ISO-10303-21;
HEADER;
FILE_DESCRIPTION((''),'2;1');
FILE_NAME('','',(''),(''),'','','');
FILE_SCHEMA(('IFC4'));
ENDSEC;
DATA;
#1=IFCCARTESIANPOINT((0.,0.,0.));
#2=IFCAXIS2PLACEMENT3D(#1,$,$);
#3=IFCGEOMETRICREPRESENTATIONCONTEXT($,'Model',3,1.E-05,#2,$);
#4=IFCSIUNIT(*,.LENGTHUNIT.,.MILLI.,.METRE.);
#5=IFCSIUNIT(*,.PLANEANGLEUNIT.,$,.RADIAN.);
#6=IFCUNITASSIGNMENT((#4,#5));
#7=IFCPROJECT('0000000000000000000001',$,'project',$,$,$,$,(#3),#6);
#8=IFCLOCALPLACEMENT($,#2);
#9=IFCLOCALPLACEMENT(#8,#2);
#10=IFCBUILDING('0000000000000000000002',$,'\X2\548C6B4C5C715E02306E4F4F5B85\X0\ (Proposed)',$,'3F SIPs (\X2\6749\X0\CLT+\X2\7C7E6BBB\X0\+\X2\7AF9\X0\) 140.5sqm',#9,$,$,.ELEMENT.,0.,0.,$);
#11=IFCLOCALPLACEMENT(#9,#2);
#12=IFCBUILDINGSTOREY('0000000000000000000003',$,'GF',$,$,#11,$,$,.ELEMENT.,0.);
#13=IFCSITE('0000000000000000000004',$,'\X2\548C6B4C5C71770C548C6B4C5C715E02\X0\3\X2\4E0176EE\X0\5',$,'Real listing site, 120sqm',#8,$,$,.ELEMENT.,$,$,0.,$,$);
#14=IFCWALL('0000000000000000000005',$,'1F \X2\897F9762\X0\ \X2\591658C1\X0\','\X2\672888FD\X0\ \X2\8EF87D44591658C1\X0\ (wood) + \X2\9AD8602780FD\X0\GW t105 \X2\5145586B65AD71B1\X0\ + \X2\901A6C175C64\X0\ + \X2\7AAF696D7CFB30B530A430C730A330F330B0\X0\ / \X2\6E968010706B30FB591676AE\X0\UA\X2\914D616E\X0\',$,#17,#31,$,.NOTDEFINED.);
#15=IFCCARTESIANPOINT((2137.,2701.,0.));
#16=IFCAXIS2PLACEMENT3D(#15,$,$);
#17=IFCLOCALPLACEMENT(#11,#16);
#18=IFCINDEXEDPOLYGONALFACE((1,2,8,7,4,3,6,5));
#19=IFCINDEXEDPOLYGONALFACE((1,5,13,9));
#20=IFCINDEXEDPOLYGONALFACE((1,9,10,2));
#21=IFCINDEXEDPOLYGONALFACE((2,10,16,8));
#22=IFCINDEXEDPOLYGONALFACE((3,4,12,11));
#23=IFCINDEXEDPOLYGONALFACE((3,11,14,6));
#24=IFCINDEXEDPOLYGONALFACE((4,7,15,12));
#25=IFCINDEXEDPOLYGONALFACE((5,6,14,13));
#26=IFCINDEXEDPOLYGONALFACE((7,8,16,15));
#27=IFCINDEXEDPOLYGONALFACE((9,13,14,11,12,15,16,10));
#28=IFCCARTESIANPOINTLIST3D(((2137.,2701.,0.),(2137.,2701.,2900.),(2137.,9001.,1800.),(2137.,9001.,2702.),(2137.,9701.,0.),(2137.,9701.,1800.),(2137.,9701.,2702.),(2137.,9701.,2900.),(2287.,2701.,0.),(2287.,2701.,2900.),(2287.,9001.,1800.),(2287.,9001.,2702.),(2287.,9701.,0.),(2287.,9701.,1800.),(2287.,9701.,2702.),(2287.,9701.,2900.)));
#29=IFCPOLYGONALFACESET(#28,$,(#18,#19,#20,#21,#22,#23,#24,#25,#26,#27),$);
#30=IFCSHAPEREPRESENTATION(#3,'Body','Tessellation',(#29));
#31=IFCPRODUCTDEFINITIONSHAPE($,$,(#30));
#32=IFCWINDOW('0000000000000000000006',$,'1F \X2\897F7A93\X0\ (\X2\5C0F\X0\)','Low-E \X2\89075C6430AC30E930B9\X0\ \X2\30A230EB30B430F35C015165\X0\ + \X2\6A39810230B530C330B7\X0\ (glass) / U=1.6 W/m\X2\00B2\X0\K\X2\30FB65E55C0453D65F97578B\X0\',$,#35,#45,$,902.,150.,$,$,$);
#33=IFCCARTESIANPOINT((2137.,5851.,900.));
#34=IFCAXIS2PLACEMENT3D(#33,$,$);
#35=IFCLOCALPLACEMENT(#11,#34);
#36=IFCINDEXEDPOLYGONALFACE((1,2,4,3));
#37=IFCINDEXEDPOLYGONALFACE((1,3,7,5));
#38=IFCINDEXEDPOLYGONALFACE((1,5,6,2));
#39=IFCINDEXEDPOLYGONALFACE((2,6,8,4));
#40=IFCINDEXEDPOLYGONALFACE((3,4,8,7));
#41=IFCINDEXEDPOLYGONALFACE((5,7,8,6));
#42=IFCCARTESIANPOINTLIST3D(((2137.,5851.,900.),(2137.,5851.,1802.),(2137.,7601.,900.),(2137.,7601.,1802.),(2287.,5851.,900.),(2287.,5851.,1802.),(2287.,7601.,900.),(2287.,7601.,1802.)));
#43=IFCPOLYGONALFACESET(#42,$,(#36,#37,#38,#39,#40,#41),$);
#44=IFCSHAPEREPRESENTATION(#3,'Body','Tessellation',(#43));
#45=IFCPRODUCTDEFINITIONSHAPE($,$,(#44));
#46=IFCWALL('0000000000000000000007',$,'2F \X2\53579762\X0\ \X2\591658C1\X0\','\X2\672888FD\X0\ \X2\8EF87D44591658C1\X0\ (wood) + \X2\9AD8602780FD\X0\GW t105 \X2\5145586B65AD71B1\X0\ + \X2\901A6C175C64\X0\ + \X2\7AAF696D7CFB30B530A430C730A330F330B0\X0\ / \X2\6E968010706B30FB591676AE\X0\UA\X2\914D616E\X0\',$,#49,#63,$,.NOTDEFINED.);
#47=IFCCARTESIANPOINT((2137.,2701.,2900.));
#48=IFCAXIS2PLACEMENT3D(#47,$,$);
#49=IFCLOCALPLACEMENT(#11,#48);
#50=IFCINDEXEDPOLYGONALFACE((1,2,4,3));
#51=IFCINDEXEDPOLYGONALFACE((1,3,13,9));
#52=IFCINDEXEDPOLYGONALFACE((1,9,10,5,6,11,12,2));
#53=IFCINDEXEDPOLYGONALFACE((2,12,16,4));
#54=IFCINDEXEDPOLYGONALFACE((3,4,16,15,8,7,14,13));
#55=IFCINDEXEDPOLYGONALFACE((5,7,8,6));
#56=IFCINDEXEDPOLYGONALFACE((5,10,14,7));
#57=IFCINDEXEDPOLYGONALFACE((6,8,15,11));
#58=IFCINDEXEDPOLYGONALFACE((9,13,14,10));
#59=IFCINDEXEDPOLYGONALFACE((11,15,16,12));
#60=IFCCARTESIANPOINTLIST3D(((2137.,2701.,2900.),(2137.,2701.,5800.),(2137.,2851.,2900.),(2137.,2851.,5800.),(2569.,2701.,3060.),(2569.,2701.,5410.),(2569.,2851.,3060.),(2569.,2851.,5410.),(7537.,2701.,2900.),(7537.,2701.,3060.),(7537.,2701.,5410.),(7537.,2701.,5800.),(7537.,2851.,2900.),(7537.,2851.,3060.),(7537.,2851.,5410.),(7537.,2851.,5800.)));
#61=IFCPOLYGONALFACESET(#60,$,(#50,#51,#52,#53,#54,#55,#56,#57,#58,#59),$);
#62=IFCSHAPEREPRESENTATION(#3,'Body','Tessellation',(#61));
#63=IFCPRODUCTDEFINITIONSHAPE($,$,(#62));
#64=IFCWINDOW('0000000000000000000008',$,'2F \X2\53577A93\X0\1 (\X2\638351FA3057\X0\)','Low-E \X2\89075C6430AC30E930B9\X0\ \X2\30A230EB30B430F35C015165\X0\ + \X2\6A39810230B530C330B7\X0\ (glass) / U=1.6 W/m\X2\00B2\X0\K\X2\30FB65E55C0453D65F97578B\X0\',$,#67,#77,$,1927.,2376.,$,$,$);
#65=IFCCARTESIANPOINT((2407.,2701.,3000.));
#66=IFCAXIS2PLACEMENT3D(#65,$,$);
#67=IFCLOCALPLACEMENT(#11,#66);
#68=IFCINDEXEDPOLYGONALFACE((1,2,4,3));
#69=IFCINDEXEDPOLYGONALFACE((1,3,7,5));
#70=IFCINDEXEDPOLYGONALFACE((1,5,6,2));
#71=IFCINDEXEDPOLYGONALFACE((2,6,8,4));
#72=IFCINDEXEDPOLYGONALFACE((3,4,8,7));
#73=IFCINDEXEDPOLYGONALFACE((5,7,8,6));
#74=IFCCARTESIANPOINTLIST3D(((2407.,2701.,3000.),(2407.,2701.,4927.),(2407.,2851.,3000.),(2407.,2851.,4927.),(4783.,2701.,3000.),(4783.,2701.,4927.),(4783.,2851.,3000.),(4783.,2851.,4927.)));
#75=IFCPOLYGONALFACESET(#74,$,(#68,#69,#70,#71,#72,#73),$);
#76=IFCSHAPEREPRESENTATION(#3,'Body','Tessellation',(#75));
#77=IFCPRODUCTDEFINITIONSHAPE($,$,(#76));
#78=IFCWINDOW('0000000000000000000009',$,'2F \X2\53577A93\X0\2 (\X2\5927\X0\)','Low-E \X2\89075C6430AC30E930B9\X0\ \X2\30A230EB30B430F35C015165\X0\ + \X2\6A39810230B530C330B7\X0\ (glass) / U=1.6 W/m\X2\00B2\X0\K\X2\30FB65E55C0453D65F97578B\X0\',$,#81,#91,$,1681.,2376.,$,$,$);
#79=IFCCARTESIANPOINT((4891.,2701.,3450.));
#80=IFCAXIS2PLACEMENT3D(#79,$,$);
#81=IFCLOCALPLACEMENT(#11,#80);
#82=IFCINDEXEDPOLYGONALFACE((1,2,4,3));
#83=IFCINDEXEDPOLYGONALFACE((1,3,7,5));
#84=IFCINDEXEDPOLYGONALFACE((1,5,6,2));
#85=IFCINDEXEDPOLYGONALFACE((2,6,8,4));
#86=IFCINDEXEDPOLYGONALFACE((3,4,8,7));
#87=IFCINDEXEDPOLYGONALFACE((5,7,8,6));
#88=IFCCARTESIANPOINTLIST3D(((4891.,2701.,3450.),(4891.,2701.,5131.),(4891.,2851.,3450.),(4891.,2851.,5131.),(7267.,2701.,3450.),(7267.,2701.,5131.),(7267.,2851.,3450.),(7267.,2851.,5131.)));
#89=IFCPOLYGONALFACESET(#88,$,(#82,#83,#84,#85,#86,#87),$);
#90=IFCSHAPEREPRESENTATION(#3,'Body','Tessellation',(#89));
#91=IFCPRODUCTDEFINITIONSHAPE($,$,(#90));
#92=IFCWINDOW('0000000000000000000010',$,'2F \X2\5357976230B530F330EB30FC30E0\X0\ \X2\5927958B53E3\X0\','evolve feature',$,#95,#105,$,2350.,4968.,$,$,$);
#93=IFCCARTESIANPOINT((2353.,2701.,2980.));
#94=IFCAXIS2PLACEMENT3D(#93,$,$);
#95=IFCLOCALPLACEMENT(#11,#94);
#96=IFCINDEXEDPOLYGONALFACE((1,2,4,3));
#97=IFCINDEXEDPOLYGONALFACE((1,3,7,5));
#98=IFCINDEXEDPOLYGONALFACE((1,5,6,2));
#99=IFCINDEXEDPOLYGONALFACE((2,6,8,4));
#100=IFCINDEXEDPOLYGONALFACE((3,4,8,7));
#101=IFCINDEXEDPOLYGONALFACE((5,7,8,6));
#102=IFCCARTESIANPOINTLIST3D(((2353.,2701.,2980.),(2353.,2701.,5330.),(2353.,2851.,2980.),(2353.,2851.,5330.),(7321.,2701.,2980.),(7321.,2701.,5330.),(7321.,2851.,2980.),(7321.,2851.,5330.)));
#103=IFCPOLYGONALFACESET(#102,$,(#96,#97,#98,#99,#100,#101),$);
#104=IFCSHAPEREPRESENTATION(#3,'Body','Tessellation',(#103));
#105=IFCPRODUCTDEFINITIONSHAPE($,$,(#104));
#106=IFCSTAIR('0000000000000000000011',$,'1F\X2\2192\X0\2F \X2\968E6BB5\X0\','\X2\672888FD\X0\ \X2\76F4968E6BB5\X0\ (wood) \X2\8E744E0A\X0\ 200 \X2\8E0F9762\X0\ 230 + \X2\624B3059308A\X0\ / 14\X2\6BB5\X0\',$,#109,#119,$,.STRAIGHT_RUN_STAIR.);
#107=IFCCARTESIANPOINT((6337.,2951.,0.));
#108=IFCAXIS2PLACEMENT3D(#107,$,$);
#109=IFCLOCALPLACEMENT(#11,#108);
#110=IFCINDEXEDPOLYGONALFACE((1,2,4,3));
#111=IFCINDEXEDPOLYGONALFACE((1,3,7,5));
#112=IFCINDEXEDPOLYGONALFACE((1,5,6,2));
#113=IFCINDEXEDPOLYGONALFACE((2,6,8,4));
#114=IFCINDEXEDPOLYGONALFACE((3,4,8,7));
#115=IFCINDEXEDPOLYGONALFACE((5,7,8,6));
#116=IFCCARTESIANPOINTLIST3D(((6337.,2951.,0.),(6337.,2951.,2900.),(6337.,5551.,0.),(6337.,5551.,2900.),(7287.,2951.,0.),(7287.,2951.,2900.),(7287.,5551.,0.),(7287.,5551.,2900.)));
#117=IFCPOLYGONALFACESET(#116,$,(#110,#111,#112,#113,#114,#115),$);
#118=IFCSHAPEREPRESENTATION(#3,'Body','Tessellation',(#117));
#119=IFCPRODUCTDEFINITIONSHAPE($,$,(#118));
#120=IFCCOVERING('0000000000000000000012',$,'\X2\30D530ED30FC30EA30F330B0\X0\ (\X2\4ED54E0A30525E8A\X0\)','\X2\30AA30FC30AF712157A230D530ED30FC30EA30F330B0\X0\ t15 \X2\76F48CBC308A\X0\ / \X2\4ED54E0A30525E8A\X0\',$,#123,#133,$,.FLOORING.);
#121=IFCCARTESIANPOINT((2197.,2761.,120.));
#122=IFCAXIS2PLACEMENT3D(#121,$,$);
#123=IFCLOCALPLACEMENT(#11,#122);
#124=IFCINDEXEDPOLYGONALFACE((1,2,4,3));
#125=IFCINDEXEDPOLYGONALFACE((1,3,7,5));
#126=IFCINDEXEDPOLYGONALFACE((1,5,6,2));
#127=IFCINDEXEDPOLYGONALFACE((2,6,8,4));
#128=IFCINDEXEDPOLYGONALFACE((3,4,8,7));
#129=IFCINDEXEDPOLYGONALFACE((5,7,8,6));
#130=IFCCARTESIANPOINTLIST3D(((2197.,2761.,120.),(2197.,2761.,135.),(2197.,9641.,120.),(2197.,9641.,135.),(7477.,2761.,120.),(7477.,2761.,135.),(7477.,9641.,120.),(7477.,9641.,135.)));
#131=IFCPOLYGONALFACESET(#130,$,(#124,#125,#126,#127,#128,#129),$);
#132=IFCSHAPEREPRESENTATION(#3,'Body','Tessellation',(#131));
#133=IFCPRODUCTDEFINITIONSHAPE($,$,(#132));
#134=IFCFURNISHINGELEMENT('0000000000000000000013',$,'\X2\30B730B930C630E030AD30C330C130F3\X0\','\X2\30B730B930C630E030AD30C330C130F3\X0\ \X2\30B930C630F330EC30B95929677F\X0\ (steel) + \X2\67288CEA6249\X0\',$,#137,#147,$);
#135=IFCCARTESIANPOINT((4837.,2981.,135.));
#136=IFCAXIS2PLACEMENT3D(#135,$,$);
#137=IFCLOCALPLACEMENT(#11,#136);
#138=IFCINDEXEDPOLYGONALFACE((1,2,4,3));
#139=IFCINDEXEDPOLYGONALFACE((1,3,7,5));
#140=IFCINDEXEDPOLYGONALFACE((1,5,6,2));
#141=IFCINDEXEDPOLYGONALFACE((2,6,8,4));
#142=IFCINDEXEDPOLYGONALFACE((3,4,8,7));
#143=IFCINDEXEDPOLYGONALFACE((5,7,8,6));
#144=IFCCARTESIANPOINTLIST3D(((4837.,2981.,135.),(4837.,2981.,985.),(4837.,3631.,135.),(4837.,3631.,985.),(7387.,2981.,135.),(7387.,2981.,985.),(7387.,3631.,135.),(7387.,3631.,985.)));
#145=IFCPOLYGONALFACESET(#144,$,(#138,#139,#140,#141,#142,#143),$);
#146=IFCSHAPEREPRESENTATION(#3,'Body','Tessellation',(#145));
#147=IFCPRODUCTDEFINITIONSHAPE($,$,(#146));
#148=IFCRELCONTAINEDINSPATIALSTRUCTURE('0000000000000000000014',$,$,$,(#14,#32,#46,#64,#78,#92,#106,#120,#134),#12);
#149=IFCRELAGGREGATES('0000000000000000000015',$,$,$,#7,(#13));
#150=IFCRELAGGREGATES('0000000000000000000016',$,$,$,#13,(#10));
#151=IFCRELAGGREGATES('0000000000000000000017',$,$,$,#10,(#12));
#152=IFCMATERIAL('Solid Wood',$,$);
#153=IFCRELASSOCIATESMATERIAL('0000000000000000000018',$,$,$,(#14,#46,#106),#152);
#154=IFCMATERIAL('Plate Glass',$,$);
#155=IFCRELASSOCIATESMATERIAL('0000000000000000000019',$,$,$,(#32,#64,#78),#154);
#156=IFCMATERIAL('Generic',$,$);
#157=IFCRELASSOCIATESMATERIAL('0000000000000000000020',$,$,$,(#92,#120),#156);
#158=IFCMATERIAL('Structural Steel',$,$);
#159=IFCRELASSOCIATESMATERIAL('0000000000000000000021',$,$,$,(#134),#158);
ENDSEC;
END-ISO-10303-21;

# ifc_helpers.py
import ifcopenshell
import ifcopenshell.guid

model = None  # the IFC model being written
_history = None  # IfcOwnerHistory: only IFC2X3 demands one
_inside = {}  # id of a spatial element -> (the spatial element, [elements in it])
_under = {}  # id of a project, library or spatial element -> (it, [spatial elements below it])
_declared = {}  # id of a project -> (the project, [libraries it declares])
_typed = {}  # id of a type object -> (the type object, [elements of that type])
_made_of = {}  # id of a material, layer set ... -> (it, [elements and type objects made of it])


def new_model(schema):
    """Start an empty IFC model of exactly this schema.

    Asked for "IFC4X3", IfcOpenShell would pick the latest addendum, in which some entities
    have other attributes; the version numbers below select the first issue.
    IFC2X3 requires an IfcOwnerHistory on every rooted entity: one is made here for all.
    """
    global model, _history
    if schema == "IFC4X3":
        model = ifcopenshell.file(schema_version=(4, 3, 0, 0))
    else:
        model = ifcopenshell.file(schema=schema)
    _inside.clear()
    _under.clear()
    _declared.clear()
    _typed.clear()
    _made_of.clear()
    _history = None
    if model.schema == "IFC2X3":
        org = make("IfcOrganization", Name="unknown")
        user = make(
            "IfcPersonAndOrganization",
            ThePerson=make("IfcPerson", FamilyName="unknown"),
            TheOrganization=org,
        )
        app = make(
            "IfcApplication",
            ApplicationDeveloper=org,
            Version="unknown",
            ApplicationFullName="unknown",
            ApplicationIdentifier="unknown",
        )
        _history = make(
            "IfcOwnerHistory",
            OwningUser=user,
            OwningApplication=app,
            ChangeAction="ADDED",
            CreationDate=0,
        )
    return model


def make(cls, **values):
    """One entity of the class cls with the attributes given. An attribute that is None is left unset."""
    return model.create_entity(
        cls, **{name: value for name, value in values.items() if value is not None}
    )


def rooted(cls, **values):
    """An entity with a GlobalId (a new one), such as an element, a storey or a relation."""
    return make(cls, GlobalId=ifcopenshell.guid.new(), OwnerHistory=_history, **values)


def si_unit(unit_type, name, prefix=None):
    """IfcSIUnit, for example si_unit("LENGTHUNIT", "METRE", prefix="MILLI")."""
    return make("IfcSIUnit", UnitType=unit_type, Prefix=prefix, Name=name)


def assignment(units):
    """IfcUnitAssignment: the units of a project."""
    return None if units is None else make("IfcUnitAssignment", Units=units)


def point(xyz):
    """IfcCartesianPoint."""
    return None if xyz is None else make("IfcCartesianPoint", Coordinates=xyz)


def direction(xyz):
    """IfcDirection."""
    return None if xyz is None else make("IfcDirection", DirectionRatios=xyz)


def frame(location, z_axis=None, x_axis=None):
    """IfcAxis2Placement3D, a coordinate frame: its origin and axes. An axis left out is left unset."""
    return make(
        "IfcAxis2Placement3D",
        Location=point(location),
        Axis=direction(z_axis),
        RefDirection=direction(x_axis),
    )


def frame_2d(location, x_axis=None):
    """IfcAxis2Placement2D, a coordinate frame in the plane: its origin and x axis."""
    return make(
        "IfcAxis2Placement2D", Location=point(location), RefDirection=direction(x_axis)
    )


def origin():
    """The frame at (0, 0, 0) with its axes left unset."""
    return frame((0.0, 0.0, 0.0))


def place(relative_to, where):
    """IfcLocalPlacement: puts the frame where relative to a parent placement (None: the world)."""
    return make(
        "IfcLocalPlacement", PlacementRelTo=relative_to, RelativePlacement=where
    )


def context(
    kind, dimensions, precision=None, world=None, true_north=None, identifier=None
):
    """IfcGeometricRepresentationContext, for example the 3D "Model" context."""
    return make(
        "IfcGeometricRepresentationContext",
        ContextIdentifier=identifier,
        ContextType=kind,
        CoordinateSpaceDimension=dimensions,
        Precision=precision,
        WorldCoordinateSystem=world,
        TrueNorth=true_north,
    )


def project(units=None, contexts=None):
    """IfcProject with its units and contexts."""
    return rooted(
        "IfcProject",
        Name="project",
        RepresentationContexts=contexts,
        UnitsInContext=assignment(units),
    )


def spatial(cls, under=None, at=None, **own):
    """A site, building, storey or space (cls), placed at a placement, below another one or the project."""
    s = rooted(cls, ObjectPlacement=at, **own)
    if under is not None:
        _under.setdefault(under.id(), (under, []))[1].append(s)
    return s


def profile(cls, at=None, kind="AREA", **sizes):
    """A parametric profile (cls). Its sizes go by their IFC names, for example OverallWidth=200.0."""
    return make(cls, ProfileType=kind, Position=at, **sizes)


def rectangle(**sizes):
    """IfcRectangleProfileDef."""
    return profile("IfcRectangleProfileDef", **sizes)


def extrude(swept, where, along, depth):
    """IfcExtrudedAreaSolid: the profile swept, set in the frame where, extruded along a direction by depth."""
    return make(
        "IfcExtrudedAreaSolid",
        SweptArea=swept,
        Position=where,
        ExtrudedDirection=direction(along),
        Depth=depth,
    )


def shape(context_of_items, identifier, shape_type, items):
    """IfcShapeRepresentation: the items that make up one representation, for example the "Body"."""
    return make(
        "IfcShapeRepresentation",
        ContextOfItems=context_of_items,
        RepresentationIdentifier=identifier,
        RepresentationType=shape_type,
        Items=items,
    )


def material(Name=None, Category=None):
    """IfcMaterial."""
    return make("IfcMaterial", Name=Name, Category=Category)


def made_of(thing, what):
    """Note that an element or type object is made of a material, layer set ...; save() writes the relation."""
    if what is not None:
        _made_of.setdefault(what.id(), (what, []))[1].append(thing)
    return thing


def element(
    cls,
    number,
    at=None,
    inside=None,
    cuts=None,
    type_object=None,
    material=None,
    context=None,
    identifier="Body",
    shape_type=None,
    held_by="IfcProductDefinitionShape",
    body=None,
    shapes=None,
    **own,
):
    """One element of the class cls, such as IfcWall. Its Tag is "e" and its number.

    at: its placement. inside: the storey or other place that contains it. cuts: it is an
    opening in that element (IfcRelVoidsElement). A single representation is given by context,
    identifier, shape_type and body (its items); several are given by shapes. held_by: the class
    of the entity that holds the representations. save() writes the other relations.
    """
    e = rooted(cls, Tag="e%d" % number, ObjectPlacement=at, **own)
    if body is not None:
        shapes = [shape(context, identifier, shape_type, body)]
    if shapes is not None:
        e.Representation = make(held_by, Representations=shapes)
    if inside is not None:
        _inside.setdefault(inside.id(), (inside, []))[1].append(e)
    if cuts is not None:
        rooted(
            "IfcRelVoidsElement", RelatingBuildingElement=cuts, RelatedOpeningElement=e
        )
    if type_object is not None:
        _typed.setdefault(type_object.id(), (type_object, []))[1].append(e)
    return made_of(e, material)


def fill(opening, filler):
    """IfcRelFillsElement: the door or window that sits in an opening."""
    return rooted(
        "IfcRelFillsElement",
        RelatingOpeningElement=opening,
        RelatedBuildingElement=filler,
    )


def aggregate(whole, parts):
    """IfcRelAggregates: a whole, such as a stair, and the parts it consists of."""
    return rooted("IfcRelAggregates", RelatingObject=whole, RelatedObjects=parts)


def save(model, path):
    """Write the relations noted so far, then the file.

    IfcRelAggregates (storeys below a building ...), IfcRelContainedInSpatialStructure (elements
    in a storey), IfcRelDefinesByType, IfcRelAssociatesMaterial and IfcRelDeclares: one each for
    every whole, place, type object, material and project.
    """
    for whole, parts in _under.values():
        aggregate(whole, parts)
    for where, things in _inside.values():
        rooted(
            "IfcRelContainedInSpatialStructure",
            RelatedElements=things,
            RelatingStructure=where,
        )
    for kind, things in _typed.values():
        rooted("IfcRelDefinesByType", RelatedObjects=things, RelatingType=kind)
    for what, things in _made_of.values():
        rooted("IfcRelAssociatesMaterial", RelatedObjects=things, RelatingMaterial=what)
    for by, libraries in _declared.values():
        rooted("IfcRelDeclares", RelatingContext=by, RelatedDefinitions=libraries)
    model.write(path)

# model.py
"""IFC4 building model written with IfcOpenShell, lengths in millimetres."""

from ifc_helpers import new_model, si_unit, frame, frame_2d, origin, place, context, project, spatial, rectangle, extrude, material, element, fill, save


model = new_model("IFC4")

# Units and contexts
model_context = context("Model", 3, precision=1e-05, world=origin())
ifc_project = project(units=[si_unit("LENGTHUNIT", "METRE", prefix="MILLI"), si_unit("PLANEANGLEUNIT", "RADIAN")], contexts=[model_context])

# Site, building, storey
site_placement = place(None, origin())
site = spatial("IfcSite", under=ifc_project, at=site_placement, Name="和歌山県和歌山市3丁目5", ObjectType="Real listing site, 120sqm", CompositionType="ELEMENT", RefElevation=0.0)
building_placement = place(site_placement, origin())
building = spatial("IfcBuilding", under=site, at=building_placement, Name="和歌山市の住宅 (Proposed)", ObjectType="3F SIPs (杉CLT+籾殻+竹) 140.5sqm", CompositionType="ELEMENT", ElevationOfRefHeight=0.0, ElevationOfTerrain=0.0)
storey_placement = place(building_placement, origin())
storey = spatial("IfcBuildingStorey", under=building, at=storey_placement, Name="GF", CompositionType="ELEMENT", Elevation=0.0)

# Shared definitions
ifc_material_1 = material(Name="Solid Wood")
ifc_material_2 = material(Name="Generic")

# Shared definitions
ifc_material_3 = material(Name="Plate Glass")

# Wall, opening, window
wall_1_placement = place(storey_placement, frame((2137.0, 2701.0, 0.0)))
wall_1 = element("IfcWall", 1, at=wall_1_placement, inside=storey, material=ifc_material_1, Name="1F 西面 外壁", Description="木製 軸組外壁 (wood) + 高性能GW t105 充填断熱 + 通気層 + 窯業系サイディング / 準耐火・外皮UA配慮", PredefinedType="NOTDEFINED", context=model_context, shape_type="SweptSolid", body=[
    extrude(rectangle(XDim=150.0, YDim=7000.0, at=frame_2d((75.0, 3500.0))), frame((2137.0, 2701.0, 0.0)), (0.0, 0.0, 1.0), 2900.0),
])
opening_1_placement = place(storey_placement, frame((2137.0, 5851.0, 900.0)))
opening_1 = element("IfcOpeningElement", 2, at=opening_1_placement, cuts=wall_1, PredefinedType="NOTDEFINED", context=model_context, shape_type="SweptSolid", body=[
    extrude(rectangle(XDim=150.0, YDim=1750.0, at=frame_2d((75.0, 875.0))), frame((2137.0, 5851.0, 900.0)), (0.0, 0.0, 1.0), 902.0),
])
window_1_placement = place(storey_placement, frame((2137.0, 5851.0, 900.0)))
window_1 = element("IfcWindow", 3, at=window_1_placement, inside=storey, material=ifc_material_3, Name="1F 西窓 (小)", Description="Low-E 複層ガラス アルゴン封入 + 樹脂サッシ (glass) / U=1.6 W/m²K・日射取得型", OverallHeight=902.0, OverallWidth=150.0, context=model_context, shape_type="SweptSolid", body=[
    extrude(rectangle(XDim=150.0, YDim=1750.0, at=frame_2d((75.0, 875.0))), frame((2137.0, 5851.0, 900.0)), (0.0, 0.0, 1.0), 902.0),
])
fill(opening_1, window_1)

# Wall, openings, windows
wall_2_placement = place(storey_placement, frame((2137.0, 2701.0, 2900.0)))
wall_2 = element("IfcWall", 4, at=wall_2_placement, inside=storey, material=ifc_material_1, Name="2F 南面 外壁", Description="木製 軸組外壁 (wood) + 高性能GW t105 充填断熱 + 通気層 + 窯業系サイディング / 準耐火・外皮UA配慮", PredefinedType="NOTDEFINED", context=model_context, shape_type="SweptSolid", body=[
    extrude(rectangle(XDim=5400.0, YDim=150.0, at=frame_2d((2700.0, 75.0))), frame((2137.0, 2701.0, 2900.0)), (0.0, 0.0, 1.0), 2900.0),
])
opening_2_placement = place(storey_placement, frame((2407.0, 2701.0, 3000.0)))
opening_2 = element("IfcOpeningElement", 5, at=opening_2_placement, cuts=wall_2, PredefinedType="NOTDEFINED", context=model_context, shape_type="SweptSolid", body=[
    extrude(rectangle(XDim=2376.0, YDim=150.0, at=frame_2d((1188.0, 75.0))), frame((2407.0, 2701.0, 3000.0)), (0.0, 0.0, 1.0), 1927.0),
])
opening_3_placement = place(storey_placement, frame((4891.0, 2701.0, 3450.0)))
opening_3 = element("IfcOpeningElement", 6, at=opening_3_placement, cuts=wall_2, PredefinedType="NOTDEFINED", context=model_context, shape_type="SweptSolid", body=[
    extrude(rectangle(XDim=2376.0, YDim=150.0, at=frame_2d((1188.0, 75.0))), frame((4891.0, 2701.0, 3450.0)), (0.0, 0.0, 1.0), 1681.0),
])
opening_4_placement = place(storey_placement, frame((2353.0, 2701.0, 2980.0)))
opening_4 = element("IfcOpeningElement", 7, at=opening_4_placement, cuts=wall_2, PredefinedType="NOTDEFINED", context=model_context, shape_type="SweptSolid", body=[
    extrude(rectangle(XDim=4968.0, YDim=150.0, at=frame_2d((2484.0, 75.0))), frame((2353.0, 2701.0, 2980.0)), (0.0, 0.0, 1.0), 2350.0),
])
window_2_placement = place(storey_placement, frame((2407.0, 2701.0, 3000.0)))
window_2 = element("IfcWindow", 8, at=window_2_placement, inside=storey, material=ifc_material_3, Name="2F 南窓1 (掃出し)", Description="Low-E 複層ガラス アルゴン封入 + 樹脂サッシ (glass) / U=1.6 W/m²K・日射取得型", OverallHeight=1927.0, OverallWidth=2376.0, context=model_context, shape_type="SweptSolid", body=[
    extrude(rectangle(XDim=2376.0, YDim=150.0, at=frame_2d((1188.0, 75.0))), frame((2407.0, 2701.0, 3000.0)), (0.0, 0.0, 1.0), 1927.0),
])
fill(opening_2, window_2)
window_3_placement = place(storey_placement, frame((4891.0, 2701.0, 3450.0)))
window_3 = element("IfcWindow", 9, at=window_3_placement, inside=storey, material=ifc_material_3, Name="2F 南窓2 (大)", Description="Low-E 複層ガラス アルゴン封入 + 樹脂サッシ (glass) / U=1.6 W/m²K・日射取得型", OverallHeight=1681.0, OverallWidth=2376.0, context=model_context, shape_type="SweptSolid", body=[
    extrude(rectangle(XDim=2376.0, YDim=150.0, at=frame_2d((1188.0, 75.0))), frame((4891.0, 2701.0, 3450.0)), (0.0, 0.0, 1.0), 1681.0),
])
fill(opening_3, window_3)
window_4_placement = place(storey_placement, frame((2353.0, 2701.0, 2980.0)))
window_4 = element("IfcWindow", 10, at=window_4_placement, inside=storey, material=ifc_material_2, Name="2F 南面サンルーム 大開口", Description="evolve feature", OverallHeight=2350.0, OverallWidth=4968.0, context=model_context, shape_type="SweptSolid", body=[
    extrude(rectangle(XDim=4968.0, YDim=150.0, at=frame_2d((2484.0, 75.0))), frame((2353.0, 2701.0, 2980.0)), (0.0, 0.0, 1.0), 2350.0),
])
fill(opening_4, window_4)

# Stair
stair_placement = place(storey_placement, frame((6337.0, 2951.0, 0.0)))
element("IfcStair", 11, at=stair_placement, inside=storey, material=ifc_material_1, Name="1F→2F 階段", Description="木製 直階段 (wood) 蹴上 200 踏面 230 + 手すり / 14段", PredefinedType="STRAIGHT_RUN_STAIR", context=model_context, shape_type="SweptSolid", body=[
    extrude(rectangle(XDim=950.0, YDim=2600.0, at=frame_2d((475.0, 1300.0))), frame((6337.0, 2951.0, 0.0)), (0.0, 0.0, 1.0), 2900.0),
])

# Covering
covering_placement = place(storey_placement, frame((2197.0, 2761.0, 120.0)))
element("IfcCovering", 12, at=covering_placement, inside=storey, material=ifc_material_2, Name="フローリング (仕上げ床)", Description="オーク無垢フローリング t15 直貼り / 仕上げ床", PredefinedType="FLOORING", context=model_context, shape_type="SweptSolid", body=[
    extrude(rectangle(XDim=5280.0, YDim=6880.0, at=frame_2d((2640.0, 3440.0))), frame((2197.0, 2761.0, 120.0)), (0.0, 0.0, 1.0), 15.0),
])

# Furnishing element
ifc_material_4 = material(Name="Structural Steel")
furnishing_placement = place(storey_placement, frame((4837.0, 2981.0, 135.0)))
element("IfcFurnishingElement", 13, at=furnishing_placement, inside=storey, material=ifc_material_4, Name="システムキッチン", Description="システムキッチン ステンレス天板 (steel) + 木質扉", context=model_context, shape_type="SweptSolid", body=[
    extrude(rectangle(XDim=2550.0, YDim=650.0, at=frame_2d((1275.0, 325.0))), frame((4837.0, 2981.0, 135.0)), (0.0, 0.0, 1.0), 850.0),
])

save(model, "model.ifc")
